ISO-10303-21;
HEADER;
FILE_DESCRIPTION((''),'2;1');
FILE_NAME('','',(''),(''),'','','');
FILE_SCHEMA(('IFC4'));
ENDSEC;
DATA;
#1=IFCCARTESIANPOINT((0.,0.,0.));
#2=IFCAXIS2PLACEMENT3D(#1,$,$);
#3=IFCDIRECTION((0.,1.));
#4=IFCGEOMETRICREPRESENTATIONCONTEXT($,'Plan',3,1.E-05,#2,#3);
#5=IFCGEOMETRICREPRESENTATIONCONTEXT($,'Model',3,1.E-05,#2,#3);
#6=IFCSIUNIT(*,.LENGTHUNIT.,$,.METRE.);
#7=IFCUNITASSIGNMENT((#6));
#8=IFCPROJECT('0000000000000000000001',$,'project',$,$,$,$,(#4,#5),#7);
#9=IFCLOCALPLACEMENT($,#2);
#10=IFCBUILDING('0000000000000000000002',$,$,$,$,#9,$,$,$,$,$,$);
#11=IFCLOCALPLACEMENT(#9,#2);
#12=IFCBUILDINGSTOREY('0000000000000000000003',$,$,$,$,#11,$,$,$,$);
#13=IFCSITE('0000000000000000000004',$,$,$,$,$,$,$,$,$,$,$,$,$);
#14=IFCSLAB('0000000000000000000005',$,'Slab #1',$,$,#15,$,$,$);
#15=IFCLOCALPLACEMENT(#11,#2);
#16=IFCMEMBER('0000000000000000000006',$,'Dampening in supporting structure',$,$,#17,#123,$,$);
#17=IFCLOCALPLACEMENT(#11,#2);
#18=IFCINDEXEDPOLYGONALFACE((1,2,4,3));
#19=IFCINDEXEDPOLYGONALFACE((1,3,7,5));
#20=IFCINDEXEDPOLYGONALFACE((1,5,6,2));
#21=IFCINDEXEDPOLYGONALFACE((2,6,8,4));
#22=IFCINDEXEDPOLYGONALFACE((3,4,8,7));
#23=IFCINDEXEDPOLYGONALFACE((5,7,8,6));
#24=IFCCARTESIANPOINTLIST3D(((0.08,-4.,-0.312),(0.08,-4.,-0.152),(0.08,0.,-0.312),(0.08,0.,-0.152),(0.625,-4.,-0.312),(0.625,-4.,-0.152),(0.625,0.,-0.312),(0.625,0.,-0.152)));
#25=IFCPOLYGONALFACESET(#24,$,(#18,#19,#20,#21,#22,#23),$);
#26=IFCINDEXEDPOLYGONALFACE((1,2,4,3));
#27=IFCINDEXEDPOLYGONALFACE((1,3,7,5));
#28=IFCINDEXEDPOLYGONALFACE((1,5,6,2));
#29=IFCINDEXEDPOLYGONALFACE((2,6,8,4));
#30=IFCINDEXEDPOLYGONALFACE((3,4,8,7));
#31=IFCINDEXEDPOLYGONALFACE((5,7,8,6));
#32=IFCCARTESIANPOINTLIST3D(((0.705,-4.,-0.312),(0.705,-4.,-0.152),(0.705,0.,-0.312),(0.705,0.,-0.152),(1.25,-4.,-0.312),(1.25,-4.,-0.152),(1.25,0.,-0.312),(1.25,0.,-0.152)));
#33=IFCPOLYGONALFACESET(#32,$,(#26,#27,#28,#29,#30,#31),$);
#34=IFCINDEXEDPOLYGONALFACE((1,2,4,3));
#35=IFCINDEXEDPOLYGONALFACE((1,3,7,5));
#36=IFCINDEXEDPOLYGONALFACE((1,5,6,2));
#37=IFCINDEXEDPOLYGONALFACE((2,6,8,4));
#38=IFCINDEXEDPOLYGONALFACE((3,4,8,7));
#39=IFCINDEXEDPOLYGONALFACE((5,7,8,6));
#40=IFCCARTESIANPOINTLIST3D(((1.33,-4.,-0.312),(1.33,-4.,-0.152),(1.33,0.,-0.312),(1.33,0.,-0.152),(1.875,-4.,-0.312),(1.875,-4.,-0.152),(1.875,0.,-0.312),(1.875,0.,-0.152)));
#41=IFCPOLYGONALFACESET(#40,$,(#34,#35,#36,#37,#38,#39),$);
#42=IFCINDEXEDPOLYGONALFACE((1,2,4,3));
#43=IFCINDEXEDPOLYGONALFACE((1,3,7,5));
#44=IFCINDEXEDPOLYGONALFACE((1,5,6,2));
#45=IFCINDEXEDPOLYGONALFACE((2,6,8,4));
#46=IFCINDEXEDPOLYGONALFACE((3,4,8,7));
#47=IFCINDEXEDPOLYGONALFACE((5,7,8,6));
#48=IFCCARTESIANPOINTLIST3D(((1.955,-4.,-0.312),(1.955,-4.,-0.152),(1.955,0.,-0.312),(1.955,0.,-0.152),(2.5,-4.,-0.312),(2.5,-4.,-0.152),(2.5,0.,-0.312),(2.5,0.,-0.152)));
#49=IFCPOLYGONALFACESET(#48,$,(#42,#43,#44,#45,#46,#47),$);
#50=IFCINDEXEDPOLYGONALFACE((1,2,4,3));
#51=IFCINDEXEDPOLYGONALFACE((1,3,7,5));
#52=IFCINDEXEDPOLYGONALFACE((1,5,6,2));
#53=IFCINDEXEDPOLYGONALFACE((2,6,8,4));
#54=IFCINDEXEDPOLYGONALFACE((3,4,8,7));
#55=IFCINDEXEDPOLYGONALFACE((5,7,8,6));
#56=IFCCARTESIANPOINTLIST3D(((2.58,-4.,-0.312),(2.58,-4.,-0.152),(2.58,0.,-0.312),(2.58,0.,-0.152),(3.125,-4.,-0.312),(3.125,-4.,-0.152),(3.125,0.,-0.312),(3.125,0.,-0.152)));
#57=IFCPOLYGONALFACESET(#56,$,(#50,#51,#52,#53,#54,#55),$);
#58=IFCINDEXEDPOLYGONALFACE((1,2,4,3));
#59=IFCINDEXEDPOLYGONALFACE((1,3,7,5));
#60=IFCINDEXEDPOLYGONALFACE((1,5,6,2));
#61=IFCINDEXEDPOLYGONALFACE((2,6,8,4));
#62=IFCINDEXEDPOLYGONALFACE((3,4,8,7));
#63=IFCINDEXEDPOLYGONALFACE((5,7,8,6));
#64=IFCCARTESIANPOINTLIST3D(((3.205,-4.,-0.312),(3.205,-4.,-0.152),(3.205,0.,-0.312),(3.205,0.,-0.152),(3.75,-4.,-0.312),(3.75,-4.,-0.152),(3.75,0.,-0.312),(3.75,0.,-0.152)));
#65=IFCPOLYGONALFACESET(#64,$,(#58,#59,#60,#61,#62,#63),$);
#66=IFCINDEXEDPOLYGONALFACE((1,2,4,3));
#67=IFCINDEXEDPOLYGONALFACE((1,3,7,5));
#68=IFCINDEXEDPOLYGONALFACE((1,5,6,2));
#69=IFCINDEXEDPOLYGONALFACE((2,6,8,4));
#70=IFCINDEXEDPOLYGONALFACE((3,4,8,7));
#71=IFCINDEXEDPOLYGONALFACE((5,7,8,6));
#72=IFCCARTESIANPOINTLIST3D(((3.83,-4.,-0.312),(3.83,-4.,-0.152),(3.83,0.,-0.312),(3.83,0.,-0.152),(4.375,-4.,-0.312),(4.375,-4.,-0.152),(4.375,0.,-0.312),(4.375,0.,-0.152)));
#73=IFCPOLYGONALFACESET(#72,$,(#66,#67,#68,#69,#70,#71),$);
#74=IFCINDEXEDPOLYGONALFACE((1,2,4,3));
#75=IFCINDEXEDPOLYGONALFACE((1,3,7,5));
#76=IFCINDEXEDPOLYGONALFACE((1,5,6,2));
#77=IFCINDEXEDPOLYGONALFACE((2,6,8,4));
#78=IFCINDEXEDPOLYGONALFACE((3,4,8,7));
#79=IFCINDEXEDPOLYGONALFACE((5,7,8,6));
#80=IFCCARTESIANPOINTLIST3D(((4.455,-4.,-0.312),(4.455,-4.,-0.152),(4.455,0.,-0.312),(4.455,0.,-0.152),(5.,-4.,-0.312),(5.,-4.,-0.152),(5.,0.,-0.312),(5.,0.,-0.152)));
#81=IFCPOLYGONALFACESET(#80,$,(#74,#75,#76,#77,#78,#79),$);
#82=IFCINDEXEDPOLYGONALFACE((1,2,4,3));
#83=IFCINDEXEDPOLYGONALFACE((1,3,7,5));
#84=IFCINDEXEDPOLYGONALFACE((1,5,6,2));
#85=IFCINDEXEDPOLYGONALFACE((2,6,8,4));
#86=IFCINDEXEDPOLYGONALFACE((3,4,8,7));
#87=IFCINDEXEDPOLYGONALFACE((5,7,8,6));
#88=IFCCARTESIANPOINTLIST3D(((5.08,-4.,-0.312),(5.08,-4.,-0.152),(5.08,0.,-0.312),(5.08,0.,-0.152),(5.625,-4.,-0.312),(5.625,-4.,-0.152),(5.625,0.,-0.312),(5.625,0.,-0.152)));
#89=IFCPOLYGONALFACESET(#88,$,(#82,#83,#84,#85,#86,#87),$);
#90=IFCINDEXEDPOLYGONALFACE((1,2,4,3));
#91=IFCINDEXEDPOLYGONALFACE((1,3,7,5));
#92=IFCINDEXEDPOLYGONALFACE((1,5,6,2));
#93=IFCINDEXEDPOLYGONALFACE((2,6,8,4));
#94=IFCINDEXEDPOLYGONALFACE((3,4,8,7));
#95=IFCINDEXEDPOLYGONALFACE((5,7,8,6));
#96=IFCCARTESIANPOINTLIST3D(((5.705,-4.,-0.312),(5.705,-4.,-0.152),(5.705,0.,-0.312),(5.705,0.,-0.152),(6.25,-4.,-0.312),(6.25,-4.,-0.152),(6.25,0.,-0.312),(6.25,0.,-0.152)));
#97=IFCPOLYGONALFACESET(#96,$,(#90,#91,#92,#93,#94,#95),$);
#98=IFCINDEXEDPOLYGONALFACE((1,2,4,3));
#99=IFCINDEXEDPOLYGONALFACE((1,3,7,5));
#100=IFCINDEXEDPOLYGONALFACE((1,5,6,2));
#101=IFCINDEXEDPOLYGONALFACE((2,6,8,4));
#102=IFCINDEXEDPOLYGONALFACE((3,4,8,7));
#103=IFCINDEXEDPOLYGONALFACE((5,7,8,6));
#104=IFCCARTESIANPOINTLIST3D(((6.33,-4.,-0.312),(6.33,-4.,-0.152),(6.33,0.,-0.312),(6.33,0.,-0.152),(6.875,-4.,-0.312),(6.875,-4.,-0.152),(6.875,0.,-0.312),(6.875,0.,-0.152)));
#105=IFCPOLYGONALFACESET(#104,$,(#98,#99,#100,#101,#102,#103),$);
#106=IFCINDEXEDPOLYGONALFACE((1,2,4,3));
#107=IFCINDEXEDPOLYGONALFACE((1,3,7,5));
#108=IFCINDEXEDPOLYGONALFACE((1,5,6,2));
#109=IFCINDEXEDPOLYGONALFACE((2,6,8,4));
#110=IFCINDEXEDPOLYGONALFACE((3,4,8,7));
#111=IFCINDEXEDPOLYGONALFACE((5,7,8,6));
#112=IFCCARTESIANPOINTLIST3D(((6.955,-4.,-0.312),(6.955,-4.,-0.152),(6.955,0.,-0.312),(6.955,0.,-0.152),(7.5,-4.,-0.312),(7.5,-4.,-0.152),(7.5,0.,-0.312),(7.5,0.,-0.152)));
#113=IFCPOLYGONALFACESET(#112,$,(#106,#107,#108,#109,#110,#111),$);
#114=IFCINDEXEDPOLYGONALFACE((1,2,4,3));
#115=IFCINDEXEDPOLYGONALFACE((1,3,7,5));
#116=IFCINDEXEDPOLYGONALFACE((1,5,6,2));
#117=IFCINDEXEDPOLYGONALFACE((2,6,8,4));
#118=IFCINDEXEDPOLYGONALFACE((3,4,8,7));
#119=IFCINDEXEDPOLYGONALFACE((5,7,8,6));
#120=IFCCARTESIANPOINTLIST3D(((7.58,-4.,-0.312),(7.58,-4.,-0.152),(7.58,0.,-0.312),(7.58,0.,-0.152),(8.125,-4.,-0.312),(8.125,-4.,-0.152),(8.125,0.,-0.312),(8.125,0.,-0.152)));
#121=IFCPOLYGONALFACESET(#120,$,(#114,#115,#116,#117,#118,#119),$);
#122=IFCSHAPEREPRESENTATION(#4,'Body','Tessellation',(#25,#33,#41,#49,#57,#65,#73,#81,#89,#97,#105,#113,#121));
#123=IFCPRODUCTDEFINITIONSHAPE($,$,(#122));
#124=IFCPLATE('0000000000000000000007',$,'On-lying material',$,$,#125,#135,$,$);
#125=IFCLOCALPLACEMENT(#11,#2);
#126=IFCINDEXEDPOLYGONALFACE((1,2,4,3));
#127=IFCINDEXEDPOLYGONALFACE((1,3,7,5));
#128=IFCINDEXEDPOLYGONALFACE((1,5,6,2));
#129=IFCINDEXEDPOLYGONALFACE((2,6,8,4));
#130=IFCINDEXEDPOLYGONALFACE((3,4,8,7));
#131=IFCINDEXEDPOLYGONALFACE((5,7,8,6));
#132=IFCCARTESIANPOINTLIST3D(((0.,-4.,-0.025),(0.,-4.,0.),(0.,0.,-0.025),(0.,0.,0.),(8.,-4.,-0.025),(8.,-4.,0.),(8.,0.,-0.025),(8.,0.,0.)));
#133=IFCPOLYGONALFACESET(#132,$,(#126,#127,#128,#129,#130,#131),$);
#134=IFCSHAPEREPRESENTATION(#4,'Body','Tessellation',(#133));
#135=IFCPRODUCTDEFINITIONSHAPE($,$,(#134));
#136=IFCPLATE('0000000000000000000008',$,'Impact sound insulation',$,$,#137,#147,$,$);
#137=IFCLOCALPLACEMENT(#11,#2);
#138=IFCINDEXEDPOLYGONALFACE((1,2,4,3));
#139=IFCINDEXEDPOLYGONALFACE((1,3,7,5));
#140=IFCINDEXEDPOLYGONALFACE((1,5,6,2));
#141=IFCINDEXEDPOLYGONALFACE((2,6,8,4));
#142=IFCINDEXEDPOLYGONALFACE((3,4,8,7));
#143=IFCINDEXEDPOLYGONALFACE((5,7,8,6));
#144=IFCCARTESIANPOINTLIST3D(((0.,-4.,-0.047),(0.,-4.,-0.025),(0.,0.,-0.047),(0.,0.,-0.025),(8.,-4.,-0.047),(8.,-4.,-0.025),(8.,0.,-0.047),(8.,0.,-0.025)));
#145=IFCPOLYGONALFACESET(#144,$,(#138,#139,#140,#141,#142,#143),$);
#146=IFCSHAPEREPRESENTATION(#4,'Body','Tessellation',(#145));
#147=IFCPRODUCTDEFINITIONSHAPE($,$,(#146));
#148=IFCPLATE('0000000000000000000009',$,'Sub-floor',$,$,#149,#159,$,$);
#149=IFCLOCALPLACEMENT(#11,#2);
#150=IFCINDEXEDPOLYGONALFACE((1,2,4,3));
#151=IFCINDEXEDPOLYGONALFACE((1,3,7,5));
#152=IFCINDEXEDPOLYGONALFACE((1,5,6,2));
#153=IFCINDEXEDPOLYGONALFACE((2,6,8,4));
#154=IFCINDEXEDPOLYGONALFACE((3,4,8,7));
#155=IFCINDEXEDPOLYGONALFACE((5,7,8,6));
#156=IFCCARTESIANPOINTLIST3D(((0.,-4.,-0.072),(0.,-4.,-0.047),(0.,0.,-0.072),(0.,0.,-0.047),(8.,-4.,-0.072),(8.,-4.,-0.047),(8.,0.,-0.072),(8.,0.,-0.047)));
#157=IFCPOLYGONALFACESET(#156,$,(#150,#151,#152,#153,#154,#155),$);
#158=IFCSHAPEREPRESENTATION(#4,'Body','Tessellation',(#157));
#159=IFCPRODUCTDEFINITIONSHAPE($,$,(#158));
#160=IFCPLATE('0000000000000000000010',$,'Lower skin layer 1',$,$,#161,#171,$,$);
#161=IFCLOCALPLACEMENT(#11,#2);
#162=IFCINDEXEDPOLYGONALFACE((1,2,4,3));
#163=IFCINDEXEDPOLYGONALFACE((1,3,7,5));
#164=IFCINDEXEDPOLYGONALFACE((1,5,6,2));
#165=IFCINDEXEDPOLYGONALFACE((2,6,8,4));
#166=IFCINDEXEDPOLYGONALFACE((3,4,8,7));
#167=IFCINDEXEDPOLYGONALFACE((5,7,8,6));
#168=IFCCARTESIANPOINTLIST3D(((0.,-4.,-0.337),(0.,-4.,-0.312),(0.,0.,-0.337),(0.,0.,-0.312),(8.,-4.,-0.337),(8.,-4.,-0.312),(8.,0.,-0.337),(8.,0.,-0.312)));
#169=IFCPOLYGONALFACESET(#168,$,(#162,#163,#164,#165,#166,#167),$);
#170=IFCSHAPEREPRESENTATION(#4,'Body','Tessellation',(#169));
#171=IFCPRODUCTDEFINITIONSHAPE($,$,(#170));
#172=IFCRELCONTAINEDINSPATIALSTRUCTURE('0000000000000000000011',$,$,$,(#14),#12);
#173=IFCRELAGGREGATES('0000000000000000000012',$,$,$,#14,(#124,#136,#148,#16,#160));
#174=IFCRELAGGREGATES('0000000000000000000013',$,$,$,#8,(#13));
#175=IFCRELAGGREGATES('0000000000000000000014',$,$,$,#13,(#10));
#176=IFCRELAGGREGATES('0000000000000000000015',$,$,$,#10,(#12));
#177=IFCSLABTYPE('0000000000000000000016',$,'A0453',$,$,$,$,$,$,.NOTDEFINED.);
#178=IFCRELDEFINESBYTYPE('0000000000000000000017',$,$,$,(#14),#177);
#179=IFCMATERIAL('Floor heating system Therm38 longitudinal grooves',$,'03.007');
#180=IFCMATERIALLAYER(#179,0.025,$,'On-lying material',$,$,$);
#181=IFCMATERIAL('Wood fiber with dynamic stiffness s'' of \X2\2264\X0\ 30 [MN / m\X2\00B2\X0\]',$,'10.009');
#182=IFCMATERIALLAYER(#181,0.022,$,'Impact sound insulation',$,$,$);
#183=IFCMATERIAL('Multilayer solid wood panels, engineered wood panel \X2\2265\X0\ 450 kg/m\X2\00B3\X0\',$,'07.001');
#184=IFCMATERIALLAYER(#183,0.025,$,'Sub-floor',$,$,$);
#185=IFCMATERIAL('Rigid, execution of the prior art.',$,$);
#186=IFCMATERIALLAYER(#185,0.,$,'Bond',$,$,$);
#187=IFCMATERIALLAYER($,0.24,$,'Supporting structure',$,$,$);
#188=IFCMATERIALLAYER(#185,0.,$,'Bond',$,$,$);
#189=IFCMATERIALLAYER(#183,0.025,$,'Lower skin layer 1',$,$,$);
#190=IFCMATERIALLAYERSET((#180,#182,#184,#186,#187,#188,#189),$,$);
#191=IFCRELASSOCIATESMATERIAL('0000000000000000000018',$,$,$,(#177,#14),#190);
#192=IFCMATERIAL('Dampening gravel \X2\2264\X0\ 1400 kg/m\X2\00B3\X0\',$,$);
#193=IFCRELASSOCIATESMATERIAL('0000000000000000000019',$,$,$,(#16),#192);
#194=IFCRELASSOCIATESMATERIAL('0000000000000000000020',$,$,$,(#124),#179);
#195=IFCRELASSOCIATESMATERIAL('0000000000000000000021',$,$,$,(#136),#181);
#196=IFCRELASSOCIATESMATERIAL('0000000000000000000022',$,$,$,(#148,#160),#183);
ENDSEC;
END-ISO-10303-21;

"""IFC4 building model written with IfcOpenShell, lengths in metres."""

from ifc_helpers import new_model, si_unit, direction, frame, frame_2d, origin, origin_with_axes, place, context, project, spatial, rectangle, extrude, material, layer, layer_set, type_object, element, aggregate, save


model = new_model("IFC4")

# Units and contexts
plan_context = context("Plan", 3, precision=1e-05, world=origin(), true_north=direction((0.0, 1.0)))
model_context = context("Model", 3, precision=1e-05, world=origin(), true_north=direction((0.0, 1.0)))
ifc_project = project(units=[si_unit("LENGTHUNIT", "METRE")], contexts=[plan_context, model_context])

# Site, building, storey
site = spatial("IfcSite", under=ifc_project)
building_placement = place(None, origin())
building = spatial("IfcBuilding", under=site, at=building_placement)
storey_placement = place(building_placement, origin())
storey = spatial("IfcBuildingStorey", under=building, at=storey_placement)

# Slab, member, plates
ifc_material_1 = material(Name="Floor heating system Therm38 longitudinal grooves", Category="03.007")
ifc_layer_1 = layer(ifc_material_1, 0.025, Name="On-lying material")
ifc_material_2 = material(Name="Wood fiber with dynamic stiffness s' of ≤ 30 [MN / m²]", Category="10.009")
ifc_layer_2 = layer(ifc_material_2, 0.022, Name="Impact sound insulation")
ifc_material_3 = material(Name="Multilayer solid wood panels, engineered wood panel ≥ 450 kg/m³", Category="07.001")
ifc_layer_3 = layer(ifc_material_3, 0.025, Name="Sub-floor")
ifc_material_4 = material(Name="Rigid, execution of the prior art.")
ifc_layer_4 = layer(ifc_material_4, 0.0, Name="Bond")
ifc_layer_5 = layer(None, 0.24, Name="Supporting structure")
ifc_layer_6 = layer(ifc_material_4, 0.0, Name="Bond")
ifc_layer_7 = layer(ifc_material_3, 0.025, Name="Lower skin layer 1")
ifc_layer_set = layer_set([ifc_layer_1, ifc_layer_2, ifc_layer_3, ifc_layer_4, ifc_layer_5, ifc_layer_6, ifc_layer_7])
slab_type = type_object("IfcSlabType", Name="A0453", PredefinedType="NOTDEFINED", material=ifc_layer_set)
slab_placement = place(None, frame((0.0, 0.0, 0.0), z_axis=(0.0, 0.0, -1.0), x_axis=(1.0, 0.0, 0.0)))
slab = element("IfcSlab", 1, at=slab_placement, inside=storey, type_object=slab_type, material=ifc_layer_set, Name="Slab #1")
ifc_material_5 = material(Name="Dampening gravel ≤ 1400 kg/m³")
member_1_placement = place(slab_placement, origin())
member_1 = element("IfcMember", 2, at=member_1_placement, material=ifc_material_5, Name="Dampening in supporting structure", context=plan_context, shape_type="SweptSolid", body=[
    extrude(rectangle(XDim=0.545, YDim=0.16, at=frame_2d((0.2725, 0.08), x_axis=(1.0, 0.0))), frame((0.08, 4.0, 0.152), z_axis=(0.0, -1.0, 0.0), x_axis=(1.0, 0.0, 0.0)), (0.0, 0.0, 1.0), 4.0),
    extrude(rectangle(XDim=0.545, YDim=0.16, at=frame_2d((0.2725, 0.08), x_axis=(1.0, 0.0))), frame((0.705, 4.0, 0.152), z_axis=(0.0, -1.0, 0.0), x_axis=(1.0, 0.0, 0.0)), (0.0, 0.0, 1.0), 4.0),
    extrude(rectangle(XDim=0.545, YDim=0.16, at=frame_2d((0.2725, 0.08), x_axis=(1.0, 0.0))), frame((1.33, 4.0, 0.152), z_axis=(0.0, -1.0, 0.0), x_axis=(1.0, 0.0, 0.0)), (0.0, 0.0, 1.0), 4.0),
    extrude(rectangle(XDim=0.545, YDim=0.16, at=frame_2d((0.2725, 0.08), x_axis=(1.0, 0.0))), frame((1.955, 4.0, 0.152), z_axis=(0.0, -1.0, 0.0), x_axis=(1.0, 0.0, 0.0)), (0.0, 0.0, 1.0), 4.0),
    extrude(rectangle(XDim=0.545, YDim=0.16, at=frame_2d((0.2725, 0.08), x_axis=(1.0, 0.0))), frame((2.58, 4.0, 0.152), z_axis=(0.0, -1.0, 0.0), x_axis=(1.0, 0.0, 0.0)), (0.0, 0.0, 1.0), 4.0),
    extrude(rectangle(XDim=0.545, YDim=0.16, at=frame_2d((0.2725, 0.08), x_axis=(1.0, 0.0))), frame((3.205, 4.0, 0.152), z_axis=(0.0, -1.0, 0.0), x_axis=(1.0, 0.0, 0.0)), (0.0, 0.0, 1.0), 4.0),
    extrude(rectangle(XDim=0.545, YDim=0.16, at=frame_2d((0.2725, 0.08), x_axis=(1.0, 0.0))), frame((3.83, 4.0, 0.152), z_axis=(0.0, -1.0, 0.0), x_axis=(1.0, 0.0, 0.0)), (0.0, 0.0, 1.0), 4.0),
    extrude(rectangle(XDim=0.545, YDim=0.16, at=frame_2d((0.2725, 0.08), x_axis=(1.0, 0.0))), frame((4.455, 4.0, 0.152), z_axis=(0.0, -1.0, 0.0), x_axis=(1.0, 0.0, 0.0)), (0.0, 0.0, 1.0), 4.0),
    extrude(rectangle(XDim=0.545, YDim=0.16, at=frame_2d((0.2725, 0.08), x_axis=(1.0, 0.0))), frame((5.08, 4.0, 0.152), z_axis=(0.0, -1.0, 0.0), x_axis=(1.0, 0.0, 0.0)), (0.0, 0.0, 1.0), 4.0),
    extrude(rectangle(XDim=0.545, YDim=0.16, at=frame_2d((0.2725, 0.08), x_axis=(1.0, 0.0))), frame((5.705, 4.0, 0.152), z_axis=(0.0, -1.0, 0.0), x_axis=(1.0, 0.0, 0.0)), (0.0, 0.0, 1.0), 4.0),
    extrude(rectangle(XDim=0.545, YDim=0.16, at=frame_2d((0.2725, 0.08), x_axis=(1.0, 0.0))), frame((6.33, 4.0, 0.152), z_axis=(0.0, -1.0, 0.0), x_axis=(1.0, 0.0, 0.0)), (0.0, 0.0, 1.0), 4.0),
    extrude(rectangle(XDim=0.545, YDim=0.16, at=frame_2d((0.2725, 0.08), x_axis=(1.0, 0.0))), frame((6.955, 4.0, 0.152), z_axis=(0.0, -1.0, 0.0), x_axis=(1.0, 0.0, 0.0)), (0.0, 0.0, 1.0), 4.0),
    extrude(rectangle(XDim=0.545, YDim=0.16, at=frame_2d((0.2725, 0.08), x_axis=(1.0, 0.0))), frame((7.58, 4.0, 0.152), z_axis=(0.0, -1.0, 0.0), x_axis=(1.0, 0.0, 0.0)), (0.0, 0.0, 1.0), 4.0),
])
plate_1_placement = place(slab_placement, origin())
plate_1 = element("IfcPlate", 3, at=plate_1_placement, material=ifc_material_1, Name="On-lying material", context=plan_context, shape_type="SweptSolid", body=[
    extrude(rectangle(XDim=8.0, YDim=4.0, at=frame_2d((4.0, 2.0), x_axis=(1.0, 0.0))), origin_with_axes(), (0.0, 0.0, 1.0), 0.025),
])
plate_2_placement = place(slab_placement, origin())
plate_2 = element("IfcPlate", 4, at=plate_2_placement, material=ifc_material_2, Name="Impact sound insulation", context=plan_context, shape_type="SweptSolid", body=[
    extrude(rectangle(XDim=8.0, YDim=4.0, at=frame_2d((4.0, 2.0), x_axis=(1.0, 0.0))), frame((0.0, 0.0, 0.025), z_axis=(0.0, 0.0, 1.0), x_axis=(1.0, 0.0, 0.0)), (0.0, 0.0, 1.0), 0.022),
])
plate_3_placement = place(slab_placement, origin())
plate_3 = element("IfcPlate", 5, at=plate_3_placement, material=ifc_material_3, Name="Sub-floor", context=plan_context, shape_type="SweptSolid", body=[
    extrude(rectangle(XDim=8.0, YDim=4.0, at=frame_2d((4.0, 2.0), x_axis=(1.0, 0.0))), frame((0.0, 0.0, 0.047), z_axis=(0.0, 0.0, 1.0), x_axis=(1.0, 0.0, 0.0)), (0.0, 0.0, 1.0), 0.025),
])
plate_4_placement = place(slab_placement, origin())
plate_4 = element("IfcPlate", 6, at=plate_4_placement, material=ifc_material_3, Name="Lower skin layer 1", context=plan_context, shape_type="SweptSolid", body=[
    extrude(rectangle(XDim=8.0, YDim=4.0, at=frame_2d((4.0, 2.0), x_axis=(1.0, 0.0))), frame((0.0, 0.0, 0.312), z_axis=(0.0, 0.0, 1.0), x_axis=(1.0, 0.0, 0.0)), (0.0, 0.0, 1.0), 0.025),
])
aggregate(slab, [plate_1, plate_2, plate_3, member_1, plate_4])

save(model, "model.ifc")
